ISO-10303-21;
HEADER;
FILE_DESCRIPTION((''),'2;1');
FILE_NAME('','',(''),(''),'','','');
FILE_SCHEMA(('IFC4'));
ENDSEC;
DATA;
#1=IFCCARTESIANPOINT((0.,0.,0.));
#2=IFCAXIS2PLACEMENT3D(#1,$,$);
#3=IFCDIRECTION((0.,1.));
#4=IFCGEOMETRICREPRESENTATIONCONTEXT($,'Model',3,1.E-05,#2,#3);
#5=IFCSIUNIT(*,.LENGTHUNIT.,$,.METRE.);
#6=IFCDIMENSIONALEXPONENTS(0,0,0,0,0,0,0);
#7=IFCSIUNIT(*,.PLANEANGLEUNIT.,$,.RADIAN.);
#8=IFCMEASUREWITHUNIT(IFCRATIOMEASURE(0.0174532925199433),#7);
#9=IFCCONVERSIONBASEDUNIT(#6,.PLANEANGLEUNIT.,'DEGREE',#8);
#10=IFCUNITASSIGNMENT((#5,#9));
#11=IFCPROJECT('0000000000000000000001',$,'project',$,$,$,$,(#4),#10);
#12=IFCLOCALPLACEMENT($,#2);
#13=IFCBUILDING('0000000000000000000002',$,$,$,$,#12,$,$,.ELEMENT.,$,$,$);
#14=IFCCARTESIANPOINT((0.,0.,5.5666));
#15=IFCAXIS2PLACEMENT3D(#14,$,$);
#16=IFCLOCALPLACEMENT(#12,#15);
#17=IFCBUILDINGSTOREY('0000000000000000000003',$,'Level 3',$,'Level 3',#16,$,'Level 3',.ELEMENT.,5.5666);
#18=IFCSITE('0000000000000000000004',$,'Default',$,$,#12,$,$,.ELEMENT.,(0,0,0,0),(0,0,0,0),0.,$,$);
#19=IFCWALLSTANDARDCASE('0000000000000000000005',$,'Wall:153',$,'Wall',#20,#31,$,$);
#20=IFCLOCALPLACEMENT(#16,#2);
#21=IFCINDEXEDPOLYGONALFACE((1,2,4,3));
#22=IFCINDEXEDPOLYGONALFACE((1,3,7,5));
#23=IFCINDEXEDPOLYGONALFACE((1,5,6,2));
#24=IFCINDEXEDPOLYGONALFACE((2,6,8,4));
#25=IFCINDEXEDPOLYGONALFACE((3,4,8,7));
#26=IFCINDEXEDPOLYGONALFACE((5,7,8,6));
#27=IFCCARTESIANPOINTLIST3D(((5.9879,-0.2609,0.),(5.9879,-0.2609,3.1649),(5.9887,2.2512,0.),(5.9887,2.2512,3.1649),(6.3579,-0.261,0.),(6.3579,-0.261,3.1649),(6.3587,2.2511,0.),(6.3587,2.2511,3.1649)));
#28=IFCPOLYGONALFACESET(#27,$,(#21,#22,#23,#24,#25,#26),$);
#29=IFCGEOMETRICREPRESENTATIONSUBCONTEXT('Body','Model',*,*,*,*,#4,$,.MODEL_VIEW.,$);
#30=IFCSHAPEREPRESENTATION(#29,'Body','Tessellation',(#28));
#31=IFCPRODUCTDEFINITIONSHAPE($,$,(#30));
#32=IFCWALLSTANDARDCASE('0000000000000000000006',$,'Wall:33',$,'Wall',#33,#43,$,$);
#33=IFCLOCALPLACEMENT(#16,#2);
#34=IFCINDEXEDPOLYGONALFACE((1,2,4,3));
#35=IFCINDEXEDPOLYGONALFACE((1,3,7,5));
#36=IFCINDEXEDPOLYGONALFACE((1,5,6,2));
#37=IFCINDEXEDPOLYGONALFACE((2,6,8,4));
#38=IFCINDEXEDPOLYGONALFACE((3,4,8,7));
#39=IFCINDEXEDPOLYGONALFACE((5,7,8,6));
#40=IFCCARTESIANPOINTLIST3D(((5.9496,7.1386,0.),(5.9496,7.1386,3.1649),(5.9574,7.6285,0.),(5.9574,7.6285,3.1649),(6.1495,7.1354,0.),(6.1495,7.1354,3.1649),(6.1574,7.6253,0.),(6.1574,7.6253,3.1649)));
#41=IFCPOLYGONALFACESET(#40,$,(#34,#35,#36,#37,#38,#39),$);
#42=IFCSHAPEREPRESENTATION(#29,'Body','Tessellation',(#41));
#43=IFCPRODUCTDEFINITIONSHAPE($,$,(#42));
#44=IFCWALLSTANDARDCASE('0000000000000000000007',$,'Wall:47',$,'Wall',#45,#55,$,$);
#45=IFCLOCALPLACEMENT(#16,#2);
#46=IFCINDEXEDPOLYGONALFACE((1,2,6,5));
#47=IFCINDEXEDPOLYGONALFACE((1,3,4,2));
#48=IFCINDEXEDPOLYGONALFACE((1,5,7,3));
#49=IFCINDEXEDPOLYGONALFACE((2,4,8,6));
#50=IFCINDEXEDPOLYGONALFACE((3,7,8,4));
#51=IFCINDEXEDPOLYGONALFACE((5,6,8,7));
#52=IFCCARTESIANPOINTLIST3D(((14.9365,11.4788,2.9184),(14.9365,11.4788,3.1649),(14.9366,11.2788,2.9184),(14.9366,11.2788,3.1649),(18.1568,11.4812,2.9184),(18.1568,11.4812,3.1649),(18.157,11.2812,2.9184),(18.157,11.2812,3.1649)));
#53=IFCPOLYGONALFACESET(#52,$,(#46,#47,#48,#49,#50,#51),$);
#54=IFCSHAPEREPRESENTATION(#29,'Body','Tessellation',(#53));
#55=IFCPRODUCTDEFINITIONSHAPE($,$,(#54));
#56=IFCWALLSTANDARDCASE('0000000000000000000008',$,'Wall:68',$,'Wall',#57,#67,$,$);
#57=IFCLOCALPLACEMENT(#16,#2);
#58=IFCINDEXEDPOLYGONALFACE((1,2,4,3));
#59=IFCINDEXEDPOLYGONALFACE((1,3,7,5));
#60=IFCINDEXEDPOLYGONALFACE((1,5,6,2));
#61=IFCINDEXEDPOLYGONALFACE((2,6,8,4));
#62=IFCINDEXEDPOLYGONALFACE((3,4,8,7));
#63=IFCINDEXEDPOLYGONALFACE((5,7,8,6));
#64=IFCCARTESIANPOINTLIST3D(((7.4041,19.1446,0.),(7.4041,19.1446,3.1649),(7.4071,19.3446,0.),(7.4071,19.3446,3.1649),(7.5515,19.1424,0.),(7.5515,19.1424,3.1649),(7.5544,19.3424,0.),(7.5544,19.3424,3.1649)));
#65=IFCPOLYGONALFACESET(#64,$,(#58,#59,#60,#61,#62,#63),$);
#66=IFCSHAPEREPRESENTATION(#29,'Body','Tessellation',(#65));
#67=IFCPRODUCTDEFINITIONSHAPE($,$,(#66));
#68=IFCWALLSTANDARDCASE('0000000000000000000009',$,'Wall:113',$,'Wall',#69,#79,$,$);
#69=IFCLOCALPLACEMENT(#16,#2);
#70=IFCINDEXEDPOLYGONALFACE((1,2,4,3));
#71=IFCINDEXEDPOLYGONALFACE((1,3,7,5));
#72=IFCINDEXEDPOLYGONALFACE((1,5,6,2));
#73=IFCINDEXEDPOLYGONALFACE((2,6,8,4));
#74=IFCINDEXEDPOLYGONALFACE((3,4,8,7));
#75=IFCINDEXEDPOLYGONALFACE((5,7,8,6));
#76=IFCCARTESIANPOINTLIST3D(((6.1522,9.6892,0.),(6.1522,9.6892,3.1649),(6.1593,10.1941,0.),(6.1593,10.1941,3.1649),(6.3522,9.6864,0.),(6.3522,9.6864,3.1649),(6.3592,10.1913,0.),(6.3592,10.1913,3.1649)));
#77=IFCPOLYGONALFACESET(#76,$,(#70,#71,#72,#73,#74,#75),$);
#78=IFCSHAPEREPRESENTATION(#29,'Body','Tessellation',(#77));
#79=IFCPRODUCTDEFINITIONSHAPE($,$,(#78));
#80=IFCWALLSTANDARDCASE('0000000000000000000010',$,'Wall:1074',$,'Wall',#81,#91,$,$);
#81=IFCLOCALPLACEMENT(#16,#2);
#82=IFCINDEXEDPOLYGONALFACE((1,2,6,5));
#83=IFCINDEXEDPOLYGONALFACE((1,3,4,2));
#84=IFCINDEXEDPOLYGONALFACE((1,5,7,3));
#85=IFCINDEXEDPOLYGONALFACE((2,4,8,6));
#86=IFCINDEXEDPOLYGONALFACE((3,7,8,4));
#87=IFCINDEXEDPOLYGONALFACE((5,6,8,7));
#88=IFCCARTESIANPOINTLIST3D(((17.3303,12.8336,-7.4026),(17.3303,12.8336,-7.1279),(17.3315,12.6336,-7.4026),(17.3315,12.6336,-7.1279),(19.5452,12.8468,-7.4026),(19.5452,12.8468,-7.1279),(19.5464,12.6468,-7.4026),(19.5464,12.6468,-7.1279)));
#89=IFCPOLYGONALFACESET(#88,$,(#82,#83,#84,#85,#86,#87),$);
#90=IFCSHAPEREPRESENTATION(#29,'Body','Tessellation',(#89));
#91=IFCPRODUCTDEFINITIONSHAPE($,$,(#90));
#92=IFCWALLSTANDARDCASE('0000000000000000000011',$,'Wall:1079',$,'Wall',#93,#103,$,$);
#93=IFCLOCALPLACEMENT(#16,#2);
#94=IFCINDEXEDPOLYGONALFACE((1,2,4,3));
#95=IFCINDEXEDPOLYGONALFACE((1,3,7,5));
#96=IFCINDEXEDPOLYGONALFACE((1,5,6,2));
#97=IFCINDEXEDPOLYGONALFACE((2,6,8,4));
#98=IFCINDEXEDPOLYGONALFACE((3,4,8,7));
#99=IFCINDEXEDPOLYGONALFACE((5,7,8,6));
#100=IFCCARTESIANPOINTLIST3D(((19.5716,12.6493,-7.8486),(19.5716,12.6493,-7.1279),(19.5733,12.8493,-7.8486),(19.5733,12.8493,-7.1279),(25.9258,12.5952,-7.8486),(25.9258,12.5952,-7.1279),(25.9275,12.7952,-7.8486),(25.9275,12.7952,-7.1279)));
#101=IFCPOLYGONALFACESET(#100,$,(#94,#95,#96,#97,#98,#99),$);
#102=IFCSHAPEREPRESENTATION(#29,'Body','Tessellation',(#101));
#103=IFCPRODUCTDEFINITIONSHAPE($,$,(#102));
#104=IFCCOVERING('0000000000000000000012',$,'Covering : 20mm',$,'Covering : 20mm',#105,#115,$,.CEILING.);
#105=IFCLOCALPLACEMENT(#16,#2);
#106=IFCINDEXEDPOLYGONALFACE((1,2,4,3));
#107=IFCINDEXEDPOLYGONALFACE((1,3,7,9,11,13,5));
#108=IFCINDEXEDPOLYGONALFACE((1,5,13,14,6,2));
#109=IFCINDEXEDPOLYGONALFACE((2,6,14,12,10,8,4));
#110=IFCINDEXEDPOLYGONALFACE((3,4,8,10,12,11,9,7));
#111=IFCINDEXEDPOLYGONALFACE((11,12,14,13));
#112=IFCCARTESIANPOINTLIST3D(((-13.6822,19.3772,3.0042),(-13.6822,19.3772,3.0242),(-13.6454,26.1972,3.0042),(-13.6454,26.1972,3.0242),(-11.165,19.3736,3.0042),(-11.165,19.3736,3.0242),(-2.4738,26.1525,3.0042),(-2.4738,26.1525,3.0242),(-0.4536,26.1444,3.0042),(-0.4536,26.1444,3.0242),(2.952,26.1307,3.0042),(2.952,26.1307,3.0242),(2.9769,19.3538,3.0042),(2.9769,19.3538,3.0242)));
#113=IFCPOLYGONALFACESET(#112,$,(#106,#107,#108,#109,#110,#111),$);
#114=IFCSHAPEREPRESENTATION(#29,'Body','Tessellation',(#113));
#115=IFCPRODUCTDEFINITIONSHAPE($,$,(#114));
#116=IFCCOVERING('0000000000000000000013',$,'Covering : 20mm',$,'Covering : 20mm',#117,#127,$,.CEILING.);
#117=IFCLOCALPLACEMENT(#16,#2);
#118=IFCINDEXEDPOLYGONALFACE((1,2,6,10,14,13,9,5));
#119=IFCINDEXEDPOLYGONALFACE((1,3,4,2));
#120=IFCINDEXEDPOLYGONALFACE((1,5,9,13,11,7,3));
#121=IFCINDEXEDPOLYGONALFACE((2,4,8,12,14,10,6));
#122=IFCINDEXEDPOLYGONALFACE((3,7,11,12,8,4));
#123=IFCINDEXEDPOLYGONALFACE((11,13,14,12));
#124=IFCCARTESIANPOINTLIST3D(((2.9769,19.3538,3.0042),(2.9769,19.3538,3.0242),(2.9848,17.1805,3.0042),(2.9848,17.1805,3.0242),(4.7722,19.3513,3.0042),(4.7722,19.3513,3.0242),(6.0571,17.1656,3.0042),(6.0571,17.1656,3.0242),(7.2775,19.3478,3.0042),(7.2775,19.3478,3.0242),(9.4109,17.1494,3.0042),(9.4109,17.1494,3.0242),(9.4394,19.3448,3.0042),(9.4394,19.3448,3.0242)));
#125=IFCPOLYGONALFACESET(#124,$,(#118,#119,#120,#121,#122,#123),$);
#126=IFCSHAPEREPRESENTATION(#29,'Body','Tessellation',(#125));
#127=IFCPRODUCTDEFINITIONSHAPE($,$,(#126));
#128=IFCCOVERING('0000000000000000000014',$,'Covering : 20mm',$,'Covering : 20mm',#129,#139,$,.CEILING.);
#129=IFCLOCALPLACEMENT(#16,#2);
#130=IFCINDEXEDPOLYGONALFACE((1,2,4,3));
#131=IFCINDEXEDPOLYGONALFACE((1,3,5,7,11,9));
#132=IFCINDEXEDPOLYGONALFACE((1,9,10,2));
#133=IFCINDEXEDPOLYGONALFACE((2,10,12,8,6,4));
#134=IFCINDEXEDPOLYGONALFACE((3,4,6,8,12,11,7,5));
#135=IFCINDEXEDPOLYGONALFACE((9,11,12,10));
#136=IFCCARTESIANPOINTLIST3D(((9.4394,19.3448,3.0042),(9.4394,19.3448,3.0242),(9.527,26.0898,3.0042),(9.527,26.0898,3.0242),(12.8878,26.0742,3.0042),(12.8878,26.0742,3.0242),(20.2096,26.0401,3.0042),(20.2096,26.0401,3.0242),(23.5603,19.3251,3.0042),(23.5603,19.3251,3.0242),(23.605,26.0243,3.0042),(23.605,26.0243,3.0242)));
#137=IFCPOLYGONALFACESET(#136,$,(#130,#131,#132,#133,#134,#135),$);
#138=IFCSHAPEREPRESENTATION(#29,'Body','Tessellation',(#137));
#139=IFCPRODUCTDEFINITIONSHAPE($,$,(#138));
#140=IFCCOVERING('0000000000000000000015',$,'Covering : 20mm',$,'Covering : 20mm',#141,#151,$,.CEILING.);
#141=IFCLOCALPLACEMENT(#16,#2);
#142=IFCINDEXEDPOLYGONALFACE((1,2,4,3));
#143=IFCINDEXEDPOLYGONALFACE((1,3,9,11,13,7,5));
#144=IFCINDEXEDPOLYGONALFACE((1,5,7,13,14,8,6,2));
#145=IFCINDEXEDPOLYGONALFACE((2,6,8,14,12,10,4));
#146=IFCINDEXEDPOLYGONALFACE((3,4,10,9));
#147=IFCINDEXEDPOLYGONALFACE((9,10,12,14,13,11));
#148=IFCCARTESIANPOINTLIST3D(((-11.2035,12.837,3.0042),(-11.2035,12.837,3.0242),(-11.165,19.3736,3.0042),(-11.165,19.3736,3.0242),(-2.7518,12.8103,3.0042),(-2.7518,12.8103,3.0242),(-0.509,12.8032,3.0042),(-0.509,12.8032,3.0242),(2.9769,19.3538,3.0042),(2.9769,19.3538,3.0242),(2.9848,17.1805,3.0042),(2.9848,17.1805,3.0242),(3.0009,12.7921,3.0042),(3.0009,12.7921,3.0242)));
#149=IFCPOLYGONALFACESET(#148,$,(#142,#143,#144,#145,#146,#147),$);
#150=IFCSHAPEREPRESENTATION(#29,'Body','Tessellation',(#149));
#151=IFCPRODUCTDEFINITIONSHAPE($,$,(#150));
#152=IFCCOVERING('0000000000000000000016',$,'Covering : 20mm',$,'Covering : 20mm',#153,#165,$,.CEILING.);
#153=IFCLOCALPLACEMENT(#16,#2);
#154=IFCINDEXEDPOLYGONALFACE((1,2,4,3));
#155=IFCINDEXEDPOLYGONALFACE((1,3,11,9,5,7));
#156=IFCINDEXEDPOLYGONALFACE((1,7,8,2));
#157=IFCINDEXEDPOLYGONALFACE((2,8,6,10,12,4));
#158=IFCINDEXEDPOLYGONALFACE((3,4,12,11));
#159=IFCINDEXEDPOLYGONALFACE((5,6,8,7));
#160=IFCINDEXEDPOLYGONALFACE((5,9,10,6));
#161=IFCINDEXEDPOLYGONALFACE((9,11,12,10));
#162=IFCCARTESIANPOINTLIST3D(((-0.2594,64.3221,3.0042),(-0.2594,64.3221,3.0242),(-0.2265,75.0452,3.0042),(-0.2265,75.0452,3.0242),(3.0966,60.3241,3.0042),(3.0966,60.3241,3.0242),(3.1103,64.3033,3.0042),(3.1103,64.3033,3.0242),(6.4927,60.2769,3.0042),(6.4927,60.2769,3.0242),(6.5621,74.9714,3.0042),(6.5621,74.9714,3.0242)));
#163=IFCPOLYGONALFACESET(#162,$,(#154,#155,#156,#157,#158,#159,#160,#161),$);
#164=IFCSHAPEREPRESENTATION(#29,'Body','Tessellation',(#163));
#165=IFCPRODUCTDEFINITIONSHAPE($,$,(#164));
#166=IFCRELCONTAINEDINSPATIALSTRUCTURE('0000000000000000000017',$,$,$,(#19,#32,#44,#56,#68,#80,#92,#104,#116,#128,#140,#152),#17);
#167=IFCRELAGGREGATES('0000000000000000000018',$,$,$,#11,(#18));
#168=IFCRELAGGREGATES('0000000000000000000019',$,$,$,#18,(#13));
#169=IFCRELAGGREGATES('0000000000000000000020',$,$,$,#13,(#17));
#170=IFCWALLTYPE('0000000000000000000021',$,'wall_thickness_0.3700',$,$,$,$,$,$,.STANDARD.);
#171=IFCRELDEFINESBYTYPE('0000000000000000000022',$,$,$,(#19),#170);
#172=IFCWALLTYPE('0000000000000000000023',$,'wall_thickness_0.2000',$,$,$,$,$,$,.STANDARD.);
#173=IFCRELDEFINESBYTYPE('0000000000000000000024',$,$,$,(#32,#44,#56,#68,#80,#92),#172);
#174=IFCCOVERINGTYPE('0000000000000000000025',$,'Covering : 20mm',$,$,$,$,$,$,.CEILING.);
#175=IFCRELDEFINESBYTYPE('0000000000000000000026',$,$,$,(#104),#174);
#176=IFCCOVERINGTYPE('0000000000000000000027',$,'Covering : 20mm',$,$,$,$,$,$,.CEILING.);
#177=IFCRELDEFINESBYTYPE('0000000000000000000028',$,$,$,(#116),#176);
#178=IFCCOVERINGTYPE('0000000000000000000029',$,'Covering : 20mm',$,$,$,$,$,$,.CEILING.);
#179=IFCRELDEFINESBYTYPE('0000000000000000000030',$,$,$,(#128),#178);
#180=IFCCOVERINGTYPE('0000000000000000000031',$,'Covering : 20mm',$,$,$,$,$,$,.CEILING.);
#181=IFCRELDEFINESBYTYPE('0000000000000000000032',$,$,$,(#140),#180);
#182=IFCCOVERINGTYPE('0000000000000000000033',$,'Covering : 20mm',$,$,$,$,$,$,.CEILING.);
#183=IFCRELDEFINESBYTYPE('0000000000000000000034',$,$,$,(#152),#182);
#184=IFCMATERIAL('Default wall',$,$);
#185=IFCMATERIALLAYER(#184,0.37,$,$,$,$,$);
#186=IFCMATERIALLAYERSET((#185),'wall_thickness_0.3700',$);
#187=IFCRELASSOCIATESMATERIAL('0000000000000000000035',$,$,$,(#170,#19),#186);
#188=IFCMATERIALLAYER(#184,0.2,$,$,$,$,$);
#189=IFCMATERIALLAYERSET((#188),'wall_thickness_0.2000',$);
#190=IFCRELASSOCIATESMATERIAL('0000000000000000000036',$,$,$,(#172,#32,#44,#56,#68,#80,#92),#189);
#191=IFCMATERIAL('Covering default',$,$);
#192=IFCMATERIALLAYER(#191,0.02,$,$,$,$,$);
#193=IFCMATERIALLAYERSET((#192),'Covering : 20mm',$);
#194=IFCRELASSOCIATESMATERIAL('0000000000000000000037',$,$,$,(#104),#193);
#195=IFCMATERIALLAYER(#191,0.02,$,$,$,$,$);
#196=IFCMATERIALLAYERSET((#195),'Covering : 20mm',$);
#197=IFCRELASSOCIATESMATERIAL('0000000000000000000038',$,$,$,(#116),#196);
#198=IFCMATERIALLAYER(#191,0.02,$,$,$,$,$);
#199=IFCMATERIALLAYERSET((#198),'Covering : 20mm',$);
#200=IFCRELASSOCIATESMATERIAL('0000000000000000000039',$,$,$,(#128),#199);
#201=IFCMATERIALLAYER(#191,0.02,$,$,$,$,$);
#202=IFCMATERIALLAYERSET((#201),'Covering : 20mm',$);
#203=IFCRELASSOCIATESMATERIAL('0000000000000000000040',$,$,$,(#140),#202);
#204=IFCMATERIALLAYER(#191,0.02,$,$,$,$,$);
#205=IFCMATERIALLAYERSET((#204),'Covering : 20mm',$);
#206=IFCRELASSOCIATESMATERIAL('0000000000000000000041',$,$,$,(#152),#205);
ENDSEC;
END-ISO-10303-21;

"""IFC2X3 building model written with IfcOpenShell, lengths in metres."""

from ifc_helpers import new_model, entity, si_unit, converted_unit, direction, frame, origin, origin_with_axes, place, context, subcontext, project, spatial, polyline, outline, extrude, material, layer, layer_set, layer_usage, type_object, element, save


model = new_model("IFC2X3")

# Units and contexts
model_context = context("Model", 3, precision=1e-05, world=origin(), true_north=direction((0.0, 1.0)))
body_context = subcontext(model_context, "Body", "Model", "MODEL_VIEW")
ifc_project = project(units=[si_unit("LENGTHUNIT", "METRE"), converted_unit("PLANEANGLEUNIT", "DEGREE", entity("IfcRatioMeasure", 0.0174532925199433), si_unit("PLANEANGLEUNIT", "RADIAN"), dimensions=[0, 0, 0, 0, 0, 0, 0])], contexts=[model_context])

# Site, building, storey
placement_1 = place(None, origin())
site = spatial("IfcSite", under=ifc_project, at=placement_1, Name="Default", CompositionType="ELEMENT", RefLatitude=(0, 0, 0, 0), RefLongitude=(0, 0, 0, 0), RefElevation=0.0)
building = spatial("IfcBuilding", under=site, at=placement_1, CompositionType="ELEMENT")
storey_placement = place(placement_1, frame((0.0, 0.0, 5.5666)))
storey = spatial("IfcBuildingStorey", under=building, at=storey_placement, Name="Level 3", ObjectType="Level 3", LongName="Level 3", CompositionType="ELEMENT", Elevation=5.5666)

# Shared definitions
ifc_material_1 = material(Name="Default wall")

# Shared definitions
ifc_layer_1 = layer(ifc_material_1, 0.37)
ifc_layer_set_1 = layer_set([ifc_layer_1], Name="wall_thickness_0.3700")
ifc_layer_usage_1 = layer_usage(ifc_layer_set_1, "AXIS2", "POSITIVE", -0.185)
wall_type_1 = type_object("IfcWallType", Name="wall_thickness_0.3700", PredefinedType="STANDARD", material=ifc_layer_set_1)

# Walls
wall_1_placement = place(storey_placement, frame((6.1737, 2.2512, 0.0), z_axis=(0.0, 0.0, 1.0), x_axis=(-0.000325, -1.0, 0.0)))
element("IfcWallStandardCase", 1, at=wall_1_placement, inside=storey, type_object=wall_type_1, material=ifc_layer_usage_1, Name="Wall:153", ObjectType="Wall", context=body_context, shape_type="SweptSolid", body=[
    extrude(outline(polyline([(2.5121, -0.185), (2.5121, 0.185), (0.0, 0.185), (0.0, -0.185), (2.5121, -0.185)])), origin(), (0.0, 0.0, 1.0), 3.1649),
])
ifc_layer_2 = layer(ifc_material_1, 0.2)
ifc_layer_set_2 = layer_set([ifc_layer_2], Name="wall_thickness_0.2000")
ifc_layer_usage_2 = layer_usage(ifc_layer_set_2, "AXIS2", "POSITIVE", -0.1)
wall_type_2 = type_object("IfcWallType", Name="wall_thickness_0.2000", PredefinedType="STANDARD", material=ifc_layer_set_2)
wall_2_placement = place(storey_placement, frame((6.0574, 7.6269, 0.0), z_axis=(0.0, 0.0, 1.0), x_axis=(-0.015976, -0.999872, 0.0)))
element("IfcWallStandardCase", 2, at=wall_2_placement, inside=storey, type_object=wall_type_2, material=ifc_layer_usage_2, Name="Wall:33", ObjectType="Wall", context=body_context, shape_type="SweptSolid", body=[
    extrude(outline(polyline([(0.49, -0.1), (0.49, 0.1), (0.0, 0.1), (0.0, -0.1), (0.49, -0.1)])), origin(), (0.0, 0.0, 1.0), 3.1649),
])
placement_2 = place(placement_1, frame((0.0, 0.0, 8.485)))
wall_3_placement = place(placement_2, frame((14.9366, 11.3788, 0.0), z_axis=(0.0, 0.0, 1.0), x_axis=(1.0, 0.000758, 0.0)))
element("IfcWallStandardCase", 3, at=wall_3_placement, inside=storey, type_object=wall_type_2, material=ifc_layer_usage_2, Name="Wall:47", ObjectType="Wall", context=body_context, shape_type="SweptSolid", body=[
    extrude(outline(polyline([(3.2203, -0.1), (3.2203, 0.1), (0.0, 0.1), (0.0, -0.1), (3.2203, -0.1)])), origin(), (0.0, 0.0, 1.0), 0.2465),
])
wall_4_placement = place(storey_placement, frame((7.5529, 19.2424, 0.0), z_axis=(0.0, 0.0, 1.0), x_axis=(-0.999888, 0.014974, 0.0)))
element("IfcWallStandardCase", 4, at=wall_4_placement, inside=storey, type_object=wall_type_2, material=ifc_layer_usage_2, Name="Wall:68", ObjectType="Wall", context=body_context, shape_type="SweptSolid", body=[
    extrude(outline(polyline([(0.1474, -0.1), (0.1474, 0.1), (0.0, 0.1), (0.0, -0.1), (0.1474, -0.1)])), origin(), (0.0, 0.0, 1.0), 3.1649),
])
wall_5_placement = place(storey_placement, frame((6.2593, 10.1927, 0.0), z_axis=(0.0, 0.0, 1.0), x_axis=(-0.013986, -0.999902, 0.0)))
element("IfcWallStandardCase", 5, at=wall_5_placement, inside=storey, type_object=wall_type_2, material=ifc_layer_usage_2, Name="Wall:113", ObjectType="Wall", context=body_context, shape_type="SweptSolid", body=[
    extrude(outline(polyline([(0.505, -0.1), (0.505, 0.1), (0.0, 0.1), (0.0, -0.1), (0.505, -0.1)])), origin(), (0.0, 0.0, 1.0), 3.1649),
])
placement_3 = place(placement_1, frame((0.0, 0.0, -1.836)))
wall_6_placement = place(placement_3, frame((17.3309, 12.7336, 0.0), z_axis=(0.0, 0.0, 1.0), x_axis=(0.999982, 0.005961, 0.0)))
element("IfcWallStandardCase", 6, at=wall_6_placement, inside=storey, type_object=wall_type_2, material=ifc_layer_usage_2, Name="Wall:1074", ObjectType="Wall", context=body_context, shape_type="SweptSolid", body=[
    extrude(outline(polyline([(2.215, -0.1), (2.215, 0.1), (0.0, 0.1), (0.0, -0.1), (2.215, -0.1)])), origin(), (0.0, 0.0, 1.0), 0.2747),
])
placement_4 = place(placement_1, frame((0.0, 0.0, -2.282)))
wall_7_placement = place(placement_4, frame((19.5724, 12.7493, 0.0), z_axis=(0.0, 0.0, 1.0), x_axis=(0.999964, -0.008518, 0.0)))
element("IfcWallStandardCase", 7, at=wall_7_placement, inside=storey, type_object=wall_type_2, material=ifc_layer_usage_2, Name="Wall:1079", ObjectType="Wall", context=body_context, shape_type="SweptSolid", body=[
    extrude(outline(polyline([(6.3544, -0.1), (6.3544, 0.1), (0.0, 0.1), (0.0, -0.1), (6.3544, -0.1)])), origin(), (0.0, 0.0, 1.0), 0.7207),
])

# Coverings
ifc_material_2 = material(Name="Covering default")
ifc_layer_3 = layer(ifc_material_2, 0.02)
ifc_layer_set_3 = layer_set([ifc_layer_3], Name="Covering : 20mm")
ifc_layer_usage_3 = layer_usage(ifc_layer_set_3, "AXIS3", "POSITIVE", 0.0)
covering_type_1 = type_object("IfcCoveringType", Name="Covering : 20mm", PredefinedType="CEILING")
covering_1_placement = place(placement_1, frame((0.0, 0.0, 8.5708)))
element("IfcCovering", 8, at=covering_1_placement, inside=storey, type_object=covering_type_1, material=ifc_layer_usage_3, Name="Covering : 20mm", ObjectType="Covering : 20mm", PredefinedType="CEILING", context=body_context, shape_type="SweptSolid", body=[
    extrude(outline(polyline([(2.9769, 19.3538), (2.952, 26.1307), (-0.4536, 26.1444), (-2.4738, 26.1525), (-13.6454, 26.1972), (-13.6822, 19.3772), (-11.165, 19.3736), (2.9769, 19.3538)])), origin_with_axes(), (0.0, 0.0, 1.0), 0.02),
])
ifc_layer_4 = layer(ifc_material_2, 0.02)
ifc_layer_set_4 = layer_set([ifc_layer_4], Name="Covering : 20mm")
ifc_layer_usage_4 = layer_usage(ifc_layer_set_4, "AXIS3", "POSITIVE", 0.0)
covering_type_2 = type_object("IfcCoveringType", Name="Covering : 20mm", PredefinedType="CEILING")
covering_2_placement = place(placement_1, frame((0.0, 0.0, 8.5708)))
element("IfcCovering", 9, at=covering_2_placement, inside=storey, type_object=covering_type_2, material=ifc_layer_usage_4, Name="Covering : 20mm", ObjectType="Covering : 20mm", PredefinedType="CEILING", context=body_context, shape_type="SweptSolid", body=[
    extrude(outline(polyline([(2.9769, 19.3538), (2.9848, 17.1805), (6.0571, 17.1656), (9.4109, 17.1494), (9.4394, 19.3448), (7.2775, 19.3478), (4.7722, 19.3513), (2.9769, 19.3538)])), origin_with_axes(), (0.0, 0.0, 1.0), 0.02),
])
ifc_layer_5 = layer(ifc_material_2, 0.02)
ifc_layer_set_5 = layer_set([ifc_layer_5], Name="Covering : 20mm")
ifc_layer_usage_5 = layer_usage(ifc_layer_set_5, "AXIS3", "POSITIVE", 0.0)
covering_type_3 = type_object("IfcCoveringType", Name="Covering : 20mm", PredefinedType="CEILING")
covering_3_placement = place(placement_1, frame((0.0, 0.0, 8.5708)))
element("IfcCovering", 10, at=covering_3_placement, inside=storey, type_object=covering_type_3, material=ifc_layer_usage_5, Name="Covering : 20mm", ObjectType="Covering : 20mm", PredefinedType="CEILING", context=body_context, shape_type="SweptSolid", body=[
    extrude(outline(polyline([(23.5603, 19.3251), (23.605, 26.0243), (20.2096, 26.0401), (12.8878, 26.0742), (9.527, 26.0898), (9.4394, 19.3448), (23.5603, 19.3251)])), origin_with_axes(), (0.0, 0.0, 1.0), 0.02),
])
ifc_layer_6 = layer(ifc_material_2, 0.02)
ifc_layer_set_6 = layer_set([ifc_layer_6], Name="Covering : 20mm")
ifc_layer_usage_6 = layer_usage(ifc_layer_set_6, "AXIS3", "POSITIVE", 0.0)
covering_type_4 = type_object("IfcCoveringType", Name="Covering : 20mm", PredefinedType="CEILING")
covering_4_placement = place(placement_1, frame((0.0, 0.0, 8.5708)))
element("IfcCovering", 11, at=covering_4_placement, inside=storey, type_object=covering_type_4, material=ifc_layer_usage_6, Name="Covering : 20mm", ObjectType="Covering : 20mm", PredefinedType="CEILING", context=body_context, shape_type="SweptSolid", body=[
    extrude(outline(polyline([(2.9769, 19.3538), (2.9848, 17.1805), (3.0009, 12.7921), (-0.509, 12.8032), (-2.7518, 12.8103), (-11.2035, 12.837), (-11.165, 19.3736), (2.9769, 19.3538)])), origin_with_axes(), (0.0, 0.0, 1.0), 0.02),
])
ifc_layer_7 = layer(ifc_material_2, 0.02)
ifc_layer_set_7 = layer_set([ifc_layer_7], Name="Covering : 20mm")
ifc_layer_usage_7 = layer_usage(ifc_layer_set_7, "AXIS3", "POSITIVE", 0.0)
covering_type_5 = type_object("IfcCoveringType", Name="Covering : 20mm", PredefinedType="CEILING")
covering_5_placement = place(placement_1, frame((0.0, 0.0, 8.5708)))
element("IfcCovering", 12, at=covering_5_placement, inside=storey, type_object=covering_type_5, material=ifc_layer_usage_7, Name="Covering : 20mm", ObjectType="Covering : 20mm", PredefinedType="CEILING", context=body_context, shape_type="SweptSolid", body=[
    extrude(outline(polyline([(6.4927, 60.2769), (3.0966, 60.3241), (3.1103, 64.3033), (-0.2594, 64.3221), (-0.2265, 75.0452), (6.5621, 74.9714), (6.4927, 60.2769)])), origin_with_axes(), (0.0, 0.0, 1.0), 0.02),
])

save(model, "model.ifc")
